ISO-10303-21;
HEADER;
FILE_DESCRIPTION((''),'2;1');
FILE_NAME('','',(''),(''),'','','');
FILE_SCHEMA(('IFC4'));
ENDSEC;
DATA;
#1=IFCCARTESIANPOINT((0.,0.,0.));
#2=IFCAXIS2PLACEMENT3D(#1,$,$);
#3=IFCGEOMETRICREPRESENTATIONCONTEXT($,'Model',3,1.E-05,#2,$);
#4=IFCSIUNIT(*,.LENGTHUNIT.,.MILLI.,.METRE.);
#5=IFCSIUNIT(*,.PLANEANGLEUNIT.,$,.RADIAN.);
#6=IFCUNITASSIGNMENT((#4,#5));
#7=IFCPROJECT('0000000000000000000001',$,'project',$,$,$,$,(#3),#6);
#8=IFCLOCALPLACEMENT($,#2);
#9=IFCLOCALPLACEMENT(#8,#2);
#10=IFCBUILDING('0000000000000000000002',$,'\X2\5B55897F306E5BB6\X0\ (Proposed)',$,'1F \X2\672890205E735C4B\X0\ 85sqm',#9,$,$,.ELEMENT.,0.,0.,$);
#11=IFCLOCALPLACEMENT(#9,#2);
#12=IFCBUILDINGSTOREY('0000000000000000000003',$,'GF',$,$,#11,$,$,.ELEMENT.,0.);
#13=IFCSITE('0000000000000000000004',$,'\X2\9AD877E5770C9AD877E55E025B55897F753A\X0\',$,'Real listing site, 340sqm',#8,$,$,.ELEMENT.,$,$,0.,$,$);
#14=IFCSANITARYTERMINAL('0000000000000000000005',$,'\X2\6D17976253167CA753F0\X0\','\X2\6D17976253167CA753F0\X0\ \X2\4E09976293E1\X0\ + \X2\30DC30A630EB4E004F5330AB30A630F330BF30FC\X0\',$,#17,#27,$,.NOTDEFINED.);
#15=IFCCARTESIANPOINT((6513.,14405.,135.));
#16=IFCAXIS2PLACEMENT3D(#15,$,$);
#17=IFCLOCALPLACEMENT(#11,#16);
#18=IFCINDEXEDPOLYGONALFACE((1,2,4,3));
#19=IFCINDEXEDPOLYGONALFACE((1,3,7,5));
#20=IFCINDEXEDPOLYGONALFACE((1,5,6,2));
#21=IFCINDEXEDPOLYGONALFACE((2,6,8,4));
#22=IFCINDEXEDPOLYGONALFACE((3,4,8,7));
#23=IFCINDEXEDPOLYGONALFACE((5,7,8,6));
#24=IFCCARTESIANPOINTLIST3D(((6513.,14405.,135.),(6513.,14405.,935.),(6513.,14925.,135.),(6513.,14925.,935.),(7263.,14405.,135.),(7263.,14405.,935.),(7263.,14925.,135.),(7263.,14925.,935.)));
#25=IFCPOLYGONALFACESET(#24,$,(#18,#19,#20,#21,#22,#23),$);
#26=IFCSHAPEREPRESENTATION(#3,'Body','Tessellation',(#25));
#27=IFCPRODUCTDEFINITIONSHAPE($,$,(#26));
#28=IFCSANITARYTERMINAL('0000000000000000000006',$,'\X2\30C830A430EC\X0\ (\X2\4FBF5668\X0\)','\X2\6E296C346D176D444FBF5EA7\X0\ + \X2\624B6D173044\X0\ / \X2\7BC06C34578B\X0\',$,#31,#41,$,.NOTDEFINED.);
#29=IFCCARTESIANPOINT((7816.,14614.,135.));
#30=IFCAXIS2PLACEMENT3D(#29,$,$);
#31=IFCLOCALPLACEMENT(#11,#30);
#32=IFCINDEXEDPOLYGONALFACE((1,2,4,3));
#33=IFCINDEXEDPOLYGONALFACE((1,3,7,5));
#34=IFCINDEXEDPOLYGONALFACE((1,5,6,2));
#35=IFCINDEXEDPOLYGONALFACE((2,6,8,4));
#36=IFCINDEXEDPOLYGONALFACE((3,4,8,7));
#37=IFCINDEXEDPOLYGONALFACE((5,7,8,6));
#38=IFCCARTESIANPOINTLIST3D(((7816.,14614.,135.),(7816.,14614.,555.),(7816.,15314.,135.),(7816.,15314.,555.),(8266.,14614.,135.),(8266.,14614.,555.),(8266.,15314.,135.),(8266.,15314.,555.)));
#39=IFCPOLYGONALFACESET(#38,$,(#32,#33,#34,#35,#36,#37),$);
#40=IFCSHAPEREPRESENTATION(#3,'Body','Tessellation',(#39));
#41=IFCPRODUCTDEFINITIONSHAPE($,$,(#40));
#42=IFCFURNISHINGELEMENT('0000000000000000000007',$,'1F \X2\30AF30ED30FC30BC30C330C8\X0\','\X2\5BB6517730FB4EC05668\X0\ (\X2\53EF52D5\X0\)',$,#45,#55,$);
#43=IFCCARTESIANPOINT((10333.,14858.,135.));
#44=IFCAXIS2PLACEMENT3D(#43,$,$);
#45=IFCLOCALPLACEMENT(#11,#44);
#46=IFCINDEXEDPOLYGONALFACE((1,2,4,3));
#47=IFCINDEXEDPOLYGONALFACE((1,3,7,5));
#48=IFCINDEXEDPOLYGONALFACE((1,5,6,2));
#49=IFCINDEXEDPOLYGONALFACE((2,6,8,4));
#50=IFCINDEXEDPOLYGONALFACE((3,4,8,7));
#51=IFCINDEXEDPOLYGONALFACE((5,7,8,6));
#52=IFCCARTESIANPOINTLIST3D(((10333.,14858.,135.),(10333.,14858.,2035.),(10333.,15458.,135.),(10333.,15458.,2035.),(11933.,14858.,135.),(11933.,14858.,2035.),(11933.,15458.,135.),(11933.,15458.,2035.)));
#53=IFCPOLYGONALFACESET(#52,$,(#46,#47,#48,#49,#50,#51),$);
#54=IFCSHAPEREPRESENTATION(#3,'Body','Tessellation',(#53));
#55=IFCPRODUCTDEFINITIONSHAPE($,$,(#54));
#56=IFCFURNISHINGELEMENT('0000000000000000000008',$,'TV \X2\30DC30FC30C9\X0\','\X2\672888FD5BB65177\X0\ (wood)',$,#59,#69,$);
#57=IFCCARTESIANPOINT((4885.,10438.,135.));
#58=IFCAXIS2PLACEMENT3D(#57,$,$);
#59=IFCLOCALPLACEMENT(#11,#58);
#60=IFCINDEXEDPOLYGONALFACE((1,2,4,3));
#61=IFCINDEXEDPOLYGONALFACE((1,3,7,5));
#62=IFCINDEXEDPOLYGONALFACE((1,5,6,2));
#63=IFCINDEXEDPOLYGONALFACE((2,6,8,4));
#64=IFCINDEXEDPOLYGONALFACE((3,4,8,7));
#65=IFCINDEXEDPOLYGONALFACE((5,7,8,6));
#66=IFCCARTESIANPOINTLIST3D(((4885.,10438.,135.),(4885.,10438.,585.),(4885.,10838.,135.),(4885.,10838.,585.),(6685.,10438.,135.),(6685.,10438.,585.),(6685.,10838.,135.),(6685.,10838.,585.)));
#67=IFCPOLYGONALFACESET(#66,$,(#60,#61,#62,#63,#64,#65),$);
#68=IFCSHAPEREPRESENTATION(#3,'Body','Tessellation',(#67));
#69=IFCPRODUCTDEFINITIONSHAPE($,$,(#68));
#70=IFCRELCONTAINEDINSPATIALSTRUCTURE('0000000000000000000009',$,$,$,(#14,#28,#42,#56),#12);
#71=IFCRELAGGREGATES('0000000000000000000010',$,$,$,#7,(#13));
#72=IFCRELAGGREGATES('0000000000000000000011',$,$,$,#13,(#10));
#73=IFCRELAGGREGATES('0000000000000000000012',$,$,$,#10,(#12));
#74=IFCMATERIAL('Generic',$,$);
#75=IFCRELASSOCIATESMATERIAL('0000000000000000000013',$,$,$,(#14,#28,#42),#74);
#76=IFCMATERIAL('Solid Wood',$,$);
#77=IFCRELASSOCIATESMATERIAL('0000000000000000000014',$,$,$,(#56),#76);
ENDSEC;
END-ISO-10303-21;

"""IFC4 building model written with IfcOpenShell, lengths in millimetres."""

from ifc_helpers import new_model, si_unit, frame, frame_2d, origin, place, context, project, spatial, rectangle, extrude, material, element, save


model = new_model("IFC4")

# Units and contexts
model_context = context("Model", 3, precision=1e-05, world=origin())
ifc_project = project(units=[si_unit("LENGTHUNIT", "METRE", prefix="MILLI"), si_unit("PLANEANGLEUNIT", "RADIAN")], contexts=[model_context])

# Site, building, storey
site_placement = place(None, origin())
site = spatial("IfcSite", under=ifc_project, at=site_placement, Name="高知県高知市孕西町", ObjectType="Real listing site, 340sqm", CompositionType="ELEMENT", RefElevation=0.0)
building_placement = place(site_placement, origin())
building = spatial("IfcBuilding", under=site, at=building_placement, Name="孕西の家 (Proposed)", ObjectType="1F 木造平屋 85sqm", CompositionType="ELEMENT", ElevationOfRefHeight=0.0, ElevationOfTerrain=0.0)
storey_placement = place(building_placement, origin())
storey = spatial("IfcBuildingStorey", under=building, at=storey_placement, Name="GF", CompositionType="ELEMENT", Elevation=0.0)

# Shared definitions
ifc_material_1 = material(Name="Solid Wood")

# Sanitary terminals
ifc_material_2 = material(Name="Generic")
sanitary_terminal_1_placement = place(storey_placement, frame((6513.0, 14405.0, 135.0)))
element("IfcSanitaryTerminal", 1, at=sanitary_terminal_1_placement, inside=storey, material=ifc_material_2, Name="洗面化粧台", Description="洗面化粧台 三面鏡 + ボウル一体カウンター", PredefinedType="NOTDEFINED", context=model_context, shape_type="SweptSolid", body=[
    extrude(rectangle(XDim=750.0, YDim=520.0, at=frame_2d((375.0, 260.0))), frame((6513.0, 14405.0, 135.0)), (0.0, 0.0, 1.0), 800.0),
])
sanitary_terminal_2_placement = place(storey_placement, frame((7816.0, 14614.0, 135.0)))
element("IfcSanitaryTerminal", 2, at=sanitary_terminal_2_placement, inside=storey, material=ifc_material_2, Name="トイレ (便器)", Description="温水洗浄便座 + 手洗い / 節水型", PredefinedType="NOTDEFINED", context=model_context, shape_type="SweptSolid", body=[
    extrude(rectangle(XDim=450.0, YDim=700.0, at=frame_2d((225.0, 350.0))), frame((7816.0, 14614.0, 135.0)), (0.0, 0.0, 1.0), 420.0),
])

# Furnishing elements
furnishing_1_placement = place(storey_placement, frame((10333.0, 14858.0, 135.0)))
element("IfcFurnishingElement", 3, at=furnishing_1_placement, inside=storey, material=ifc_material_2, Name="1F クローゼット", Description="家具・什器 (可動)", context=model_context, shape_type="SweptSolid", body=[
    extrude(rectangle(XDim=1600.0, YDim=600.0, at=frame_2d((800.0, 300.0))), frame((10333.0, 14858.0, 135.0)), (0.0, 0.0, 1.0), 1900.0),
])
furnishing_2_placement = place(storey_placement, frame((4885.0, 10438.0, 135.0)))
element("IfcFurnishingElement", 4, at=furnishing_2_placement, inside=storey, material=ifc_material_1, Name="TV ボード", Description="木製家具 (wood)", context=model_context, shape_type="SweptSolid", body=[
    extrude(rectangle(XDim=1800.0, YDim=400.0, at=frame_2d((900.0, 200.0))), frame((4885.0, 10438.0, 135.0)), (0.0, 0.0, 1.0), 450.0),
])

save(model, "model.ifc")
